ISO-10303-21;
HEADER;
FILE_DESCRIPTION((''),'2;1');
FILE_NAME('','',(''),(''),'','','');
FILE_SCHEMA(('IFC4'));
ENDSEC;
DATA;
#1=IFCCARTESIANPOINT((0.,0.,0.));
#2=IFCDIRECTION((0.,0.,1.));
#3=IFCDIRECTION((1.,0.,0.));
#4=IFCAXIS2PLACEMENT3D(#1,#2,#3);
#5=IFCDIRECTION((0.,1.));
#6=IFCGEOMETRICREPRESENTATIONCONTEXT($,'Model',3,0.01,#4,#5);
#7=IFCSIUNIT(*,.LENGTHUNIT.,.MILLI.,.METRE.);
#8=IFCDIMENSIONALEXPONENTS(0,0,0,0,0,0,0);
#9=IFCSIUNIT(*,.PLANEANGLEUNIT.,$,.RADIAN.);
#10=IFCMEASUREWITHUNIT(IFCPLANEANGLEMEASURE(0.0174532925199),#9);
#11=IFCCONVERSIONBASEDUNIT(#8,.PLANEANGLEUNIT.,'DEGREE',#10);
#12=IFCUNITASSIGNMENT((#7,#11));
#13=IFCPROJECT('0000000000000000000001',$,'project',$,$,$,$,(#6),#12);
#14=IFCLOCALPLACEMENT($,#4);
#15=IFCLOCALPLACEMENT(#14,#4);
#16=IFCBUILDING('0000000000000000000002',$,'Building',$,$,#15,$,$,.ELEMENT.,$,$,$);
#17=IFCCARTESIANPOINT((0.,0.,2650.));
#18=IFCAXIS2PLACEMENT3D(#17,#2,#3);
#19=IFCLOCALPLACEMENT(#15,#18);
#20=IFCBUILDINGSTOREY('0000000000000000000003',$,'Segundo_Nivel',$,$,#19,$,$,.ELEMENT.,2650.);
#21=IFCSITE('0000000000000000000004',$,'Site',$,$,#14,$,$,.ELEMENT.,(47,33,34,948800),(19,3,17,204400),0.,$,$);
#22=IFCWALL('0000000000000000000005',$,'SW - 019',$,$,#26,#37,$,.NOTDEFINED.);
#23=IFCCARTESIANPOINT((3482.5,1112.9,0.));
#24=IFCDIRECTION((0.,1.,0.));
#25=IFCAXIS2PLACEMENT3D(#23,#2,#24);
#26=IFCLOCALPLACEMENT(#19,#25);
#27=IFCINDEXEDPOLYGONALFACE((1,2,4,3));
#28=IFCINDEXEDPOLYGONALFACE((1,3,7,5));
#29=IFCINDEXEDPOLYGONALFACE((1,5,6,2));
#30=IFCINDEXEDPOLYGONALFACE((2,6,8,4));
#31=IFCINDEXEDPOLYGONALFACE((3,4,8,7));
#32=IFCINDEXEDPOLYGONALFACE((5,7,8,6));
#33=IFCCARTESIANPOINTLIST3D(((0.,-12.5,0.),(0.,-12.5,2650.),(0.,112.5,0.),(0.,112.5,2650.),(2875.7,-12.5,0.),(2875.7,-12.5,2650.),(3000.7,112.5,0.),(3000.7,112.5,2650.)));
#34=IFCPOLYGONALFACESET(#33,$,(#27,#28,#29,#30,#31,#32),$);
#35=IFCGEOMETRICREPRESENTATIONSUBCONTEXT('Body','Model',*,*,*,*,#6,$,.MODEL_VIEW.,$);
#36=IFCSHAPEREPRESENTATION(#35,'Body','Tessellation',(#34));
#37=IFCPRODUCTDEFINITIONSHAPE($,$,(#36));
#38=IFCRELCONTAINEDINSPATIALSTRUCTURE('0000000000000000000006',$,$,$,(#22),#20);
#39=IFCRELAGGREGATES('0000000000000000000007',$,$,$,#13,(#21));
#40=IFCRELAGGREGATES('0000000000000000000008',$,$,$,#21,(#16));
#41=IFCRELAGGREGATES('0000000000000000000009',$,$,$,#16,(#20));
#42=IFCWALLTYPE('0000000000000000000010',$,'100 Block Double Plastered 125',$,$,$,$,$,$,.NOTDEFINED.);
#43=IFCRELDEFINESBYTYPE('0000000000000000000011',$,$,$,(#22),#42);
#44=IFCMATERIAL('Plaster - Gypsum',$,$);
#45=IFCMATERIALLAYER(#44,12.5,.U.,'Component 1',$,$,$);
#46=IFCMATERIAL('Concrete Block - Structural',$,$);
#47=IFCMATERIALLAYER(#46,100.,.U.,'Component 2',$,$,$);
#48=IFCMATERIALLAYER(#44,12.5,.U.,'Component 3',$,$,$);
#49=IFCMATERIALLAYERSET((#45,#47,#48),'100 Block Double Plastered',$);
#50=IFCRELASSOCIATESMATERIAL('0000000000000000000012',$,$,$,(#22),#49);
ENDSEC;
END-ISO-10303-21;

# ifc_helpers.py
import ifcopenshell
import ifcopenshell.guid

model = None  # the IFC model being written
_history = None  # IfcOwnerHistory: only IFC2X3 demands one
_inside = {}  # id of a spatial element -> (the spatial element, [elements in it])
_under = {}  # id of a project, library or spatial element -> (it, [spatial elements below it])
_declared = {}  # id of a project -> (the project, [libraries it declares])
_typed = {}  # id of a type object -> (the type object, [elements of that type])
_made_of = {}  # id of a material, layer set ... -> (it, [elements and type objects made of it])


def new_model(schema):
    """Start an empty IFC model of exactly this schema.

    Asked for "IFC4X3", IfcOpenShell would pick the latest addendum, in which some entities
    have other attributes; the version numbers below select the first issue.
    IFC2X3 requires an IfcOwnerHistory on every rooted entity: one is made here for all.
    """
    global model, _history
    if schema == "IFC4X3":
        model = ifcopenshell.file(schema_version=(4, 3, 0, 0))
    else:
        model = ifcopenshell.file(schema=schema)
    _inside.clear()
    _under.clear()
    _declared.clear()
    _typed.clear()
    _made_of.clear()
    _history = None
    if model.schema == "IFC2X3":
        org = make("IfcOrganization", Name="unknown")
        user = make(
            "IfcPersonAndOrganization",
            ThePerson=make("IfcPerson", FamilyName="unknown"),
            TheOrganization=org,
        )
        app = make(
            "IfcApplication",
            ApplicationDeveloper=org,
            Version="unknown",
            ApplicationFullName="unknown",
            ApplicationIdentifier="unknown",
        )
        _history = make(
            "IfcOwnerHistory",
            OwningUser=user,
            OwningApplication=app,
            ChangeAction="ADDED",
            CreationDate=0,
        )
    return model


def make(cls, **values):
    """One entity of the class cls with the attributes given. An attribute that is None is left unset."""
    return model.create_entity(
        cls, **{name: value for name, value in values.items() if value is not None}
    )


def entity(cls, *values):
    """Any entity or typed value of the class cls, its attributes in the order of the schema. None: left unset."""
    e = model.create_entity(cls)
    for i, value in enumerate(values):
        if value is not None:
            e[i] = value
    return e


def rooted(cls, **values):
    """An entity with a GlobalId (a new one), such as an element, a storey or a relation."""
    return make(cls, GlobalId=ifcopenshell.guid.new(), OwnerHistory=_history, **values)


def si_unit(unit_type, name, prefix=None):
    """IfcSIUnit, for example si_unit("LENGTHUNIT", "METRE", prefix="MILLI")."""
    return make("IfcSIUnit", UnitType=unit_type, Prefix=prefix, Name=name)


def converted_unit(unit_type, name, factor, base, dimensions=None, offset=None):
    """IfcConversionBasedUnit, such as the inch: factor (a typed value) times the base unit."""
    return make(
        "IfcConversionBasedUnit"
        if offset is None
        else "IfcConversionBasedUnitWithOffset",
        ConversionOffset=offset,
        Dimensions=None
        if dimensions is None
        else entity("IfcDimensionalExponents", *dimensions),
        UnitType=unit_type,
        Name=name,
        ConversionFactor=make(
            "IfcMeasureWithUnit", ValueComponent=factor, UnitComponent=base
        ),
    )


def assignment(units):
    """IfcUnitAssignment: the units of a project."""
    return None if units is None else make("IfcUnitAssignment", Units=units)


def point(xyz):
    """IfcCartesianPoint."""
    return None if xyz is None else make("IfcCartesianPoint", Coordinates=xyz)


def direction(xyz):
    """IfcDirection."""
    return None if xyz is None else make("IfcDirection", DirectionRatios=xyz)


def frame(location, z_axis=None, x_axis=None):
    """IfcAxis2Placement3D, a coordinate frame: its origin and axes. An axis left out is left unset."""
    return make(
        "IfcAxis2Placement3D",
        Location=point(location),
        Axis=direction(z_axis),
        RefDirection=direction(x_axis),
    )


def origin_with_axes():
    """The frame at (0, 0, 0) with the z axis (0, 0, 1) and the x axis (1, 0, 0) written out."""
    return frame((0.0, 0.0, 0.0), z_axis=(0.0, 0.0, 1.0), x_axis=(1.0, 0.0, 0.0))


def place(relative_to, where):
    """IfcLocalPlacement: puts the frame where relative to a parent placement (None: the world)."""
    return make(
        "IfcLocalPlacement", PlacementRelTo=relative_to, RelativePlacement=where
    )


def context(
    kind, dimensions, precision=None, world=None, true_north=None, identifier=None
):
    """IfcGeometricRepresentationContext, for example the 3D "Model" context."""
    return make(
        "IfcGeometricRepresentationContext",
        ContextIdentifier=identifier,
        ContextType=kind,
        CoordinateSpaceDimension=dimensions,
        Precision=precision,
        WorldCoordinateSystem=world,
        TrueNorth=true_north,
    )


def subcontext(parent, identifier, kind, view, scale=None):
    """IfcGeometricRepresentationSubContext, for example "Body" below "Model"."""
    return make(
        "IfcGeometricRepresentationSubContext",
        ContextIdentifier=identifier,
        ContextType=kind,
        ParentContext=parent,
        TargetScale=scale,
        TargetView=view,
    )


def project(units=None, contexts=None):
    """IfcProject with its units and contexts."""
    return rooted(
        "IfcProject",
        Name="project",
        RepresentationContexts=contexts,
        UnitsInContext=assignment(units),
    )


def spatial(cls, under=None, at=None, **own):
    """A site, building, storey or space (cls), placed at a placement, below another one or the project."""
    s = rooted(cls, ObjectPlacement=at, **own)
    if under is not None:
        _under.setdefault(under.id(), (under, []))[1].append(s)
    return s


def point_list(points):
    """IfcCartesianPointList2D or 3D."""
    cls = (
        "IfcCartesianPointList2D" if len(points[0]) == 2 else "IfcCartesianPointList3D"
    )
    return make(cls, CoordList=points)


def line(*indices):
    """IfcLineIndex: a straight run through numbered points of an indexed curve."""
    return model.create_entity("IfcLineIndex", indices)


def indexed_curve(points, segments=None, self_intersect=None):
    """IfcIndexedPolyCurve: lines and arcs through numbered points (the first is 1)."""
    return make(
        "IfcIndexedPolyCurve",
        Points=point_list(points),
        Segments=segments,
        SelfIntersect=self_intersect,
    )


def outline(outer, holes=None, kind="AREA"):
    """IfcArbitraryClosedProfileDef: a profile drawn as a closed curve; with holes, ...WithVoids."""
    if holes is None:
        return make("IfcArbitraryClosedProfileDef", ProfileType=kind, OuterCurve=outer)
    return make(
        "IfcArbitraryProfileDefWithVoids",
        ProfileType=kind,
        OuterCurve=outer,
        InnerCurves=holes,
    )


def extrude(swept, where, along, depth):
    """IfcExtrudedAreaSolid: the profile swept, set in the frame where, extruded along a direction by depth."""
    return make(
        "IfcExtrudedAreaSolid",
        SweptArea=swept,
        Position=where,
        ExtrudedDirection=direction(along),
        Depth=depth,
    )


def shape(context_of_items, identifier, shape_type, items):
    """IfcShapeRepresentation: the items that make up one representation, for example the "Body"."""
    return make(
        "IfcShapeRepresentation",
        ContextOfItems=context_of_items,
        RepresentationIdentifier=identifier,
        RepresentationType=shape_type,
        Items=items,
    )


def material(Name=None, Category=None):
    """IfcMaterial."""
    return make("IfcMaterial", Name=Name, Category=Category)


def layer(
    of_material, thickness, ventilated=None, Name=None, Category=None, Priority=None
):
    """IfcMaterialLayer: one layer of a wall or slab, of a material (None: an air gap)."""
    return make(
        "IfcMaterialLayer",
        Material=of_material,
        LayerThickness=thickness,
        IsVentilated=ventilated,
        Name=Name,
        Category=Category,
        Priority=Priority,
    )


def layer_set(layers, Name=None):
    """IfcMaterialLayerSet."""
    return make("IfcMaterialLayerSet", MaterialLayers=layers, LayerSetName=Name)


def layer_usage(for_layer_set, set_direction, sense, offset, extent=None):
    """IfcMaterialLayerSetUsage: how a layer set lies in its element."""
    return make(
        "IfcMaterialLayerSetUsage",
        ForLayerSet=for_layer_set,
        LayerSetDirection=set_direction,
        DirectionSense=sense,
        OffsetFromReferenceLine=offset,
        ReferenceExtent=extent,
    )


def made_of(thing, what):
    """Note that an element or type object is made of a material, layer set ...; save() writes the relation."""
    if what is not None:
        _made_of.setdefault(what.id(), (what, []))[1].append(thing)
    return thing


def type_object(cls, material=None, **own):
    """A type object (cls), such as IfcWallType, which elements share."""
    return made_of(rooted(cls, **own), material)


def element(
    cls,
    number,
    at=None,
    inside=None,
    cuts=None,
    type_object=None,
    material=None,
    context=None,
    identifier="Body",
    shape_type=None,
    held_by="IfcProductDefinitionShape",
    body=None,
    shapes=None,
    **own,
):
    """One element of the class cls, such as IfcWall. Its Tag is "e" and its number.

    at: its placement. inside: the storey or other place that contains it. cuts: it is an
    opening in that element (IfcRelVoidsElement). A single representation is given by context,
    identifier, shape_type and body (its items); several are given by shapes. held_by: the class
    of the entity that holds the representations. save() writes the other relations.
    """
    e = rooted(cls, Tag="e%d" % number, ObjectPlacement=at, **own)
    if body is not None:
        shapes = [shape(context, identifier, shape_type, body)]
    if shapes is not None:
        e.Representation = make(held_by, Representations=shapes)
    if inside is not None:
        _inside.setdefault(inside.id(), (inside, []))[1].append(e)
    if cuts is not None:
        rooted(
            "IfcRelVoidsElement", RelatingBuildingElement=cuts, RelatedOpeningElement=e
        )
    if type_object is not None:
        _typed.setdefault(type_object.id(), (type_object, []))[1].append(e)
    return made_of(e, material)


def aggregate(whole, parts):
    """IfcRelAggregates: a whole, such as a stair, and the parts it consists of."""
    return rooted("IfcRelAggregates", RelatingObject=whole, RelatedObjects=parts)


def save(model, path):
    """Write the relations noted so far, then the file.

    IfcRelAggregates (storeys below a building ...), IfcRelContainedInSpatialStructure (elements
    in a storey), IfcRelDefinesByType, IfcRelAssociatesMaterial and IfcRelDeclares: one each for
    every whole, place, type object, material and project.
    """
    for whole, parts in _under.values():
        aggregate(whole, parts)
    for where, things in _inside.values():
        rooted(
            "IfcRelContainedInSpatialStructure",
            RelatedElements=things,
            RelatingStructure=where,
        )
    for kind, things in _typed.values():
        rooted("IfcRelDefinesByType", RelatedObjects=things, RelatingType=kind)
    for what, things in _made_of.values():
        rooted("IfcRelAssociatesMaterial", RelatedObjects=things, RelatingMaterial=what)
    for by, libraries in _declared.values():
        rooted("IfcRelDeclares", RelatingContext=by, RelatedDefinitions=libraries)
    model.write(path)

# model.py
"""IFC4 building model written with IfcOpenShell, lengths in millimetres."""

from ifc_helpers import new_model, entity, si_unit, converted_unit, direction, frame, origin_with_axes, place, context, subcontext, project, spatial, line, indexed_curve, outline, extrude, material, layer, layer_set, layer_usage, type_object, element, save


model = new_model("IFC4")

# Units and contexts
model_context = context("Model", 3, precision=0.01, world=origin_with_axes(), true_north=direction((0.0, 1.0)))
body_context = subcontext(model_context, "Body", "Model", "MODEL_VIEW")
ifc_project = project(units=[si_unit("LENGTHUNIT", "METRE", prefix="MILLI"), converted_unit("PLANEANGLEUNIT", "DEGREE", entity("IfcPlaneAngleMeasure", 0.0174532925199), si_unit("PLANEANGLEUNIT", "RADIAN"), dimensions=[0, 0, 0, 0, 0, 0, 0])], contexts=[model_context])

# Site, building, storey
site_placement = place(None, origin_with_axes())
site = spatial("IfcSite", under=ifc_project, at=site_placement, Name="Site", CompositionType="ELEMENT", RefLatitude=(47, 33, 34, 948800), RefLongitude=(19, 3, 17, 204400), RefElevation=0.0)
building_placement = place(site_placement, origin_with_axes())
building = spatial("IfcBuilding", under=site, at=building_placement, Name="Building", CompositionType="ELEMENT")
storey_placement = place(building_placement, frame((0.0, 0.0, 2650.0), z_axis=(0.0, 0.0, 1.0), x_axis=(1.0, 0.0, 0.0)))
storey = spatial("IfcBuildingStorey", under=building, at=storey_placement, Name="Segundo_Nivel", CompositionType="ELEMENT", Elevation=2650.0)

# Shared definitions
ifc_material_1 = material(Name="Plaster - Gypsum")

# Wall
ifc_layer_1 = layer(ifc_material_1, 12.5, ventilated="UNKNOWN", Name="Component 1")
ifc_material_2 = material(Name="Concrete Block - Structural")
ifc_layer_2 = layer(ifc_material_2, 100.0, ventilated="UNKNOWN", Name="Component 2")
ifc_layer_3 = layer(ifc_material_1, 12.5, ventilated="UNKNOWN", Name="Component 3")
ifc_layer_set_1 = layer_set([ifc_layer_1, ifc_layer_2, ifc_layer_3], Name="100 Block Double Plastered")
ifc_layer_usage_1 = layer_usage(ifc_layer_set_1, "AXIS2", "POSITIVE", -12.5)
wall_type_1 = type_object("IfcWallType", Name="100 Block Double Plastered 125", PredefinedType="NOTDEFINED")
wall_1_placement = place(storey_placement, frame((3482.5, 1112.9, 0.0), z_axis=(0.0, 0.0, 1.0), x_axis=(0.0, 1.0, 0.0)))
element("IfcWall", 1, at=wall_1_placement, inside=storey, type_object=wall_type_1, material=ifc_layer_usage_1, Name="SW - 019", PredefinedType="NOTDEFINED", context=body_context, shape_type="SweptSolid", body=[
    extrude(outline(indexed_curve([(0.0, -12.5), (2875.7, -12.5), (3000.7, 112.5), (0.0, 112.5)], segments=[line(1, 2, 3, 4, 1)])), origin_with_axes(), (0.0, 0.0, 1.0), 2650.0),
])

save(model, "model.ifc")
